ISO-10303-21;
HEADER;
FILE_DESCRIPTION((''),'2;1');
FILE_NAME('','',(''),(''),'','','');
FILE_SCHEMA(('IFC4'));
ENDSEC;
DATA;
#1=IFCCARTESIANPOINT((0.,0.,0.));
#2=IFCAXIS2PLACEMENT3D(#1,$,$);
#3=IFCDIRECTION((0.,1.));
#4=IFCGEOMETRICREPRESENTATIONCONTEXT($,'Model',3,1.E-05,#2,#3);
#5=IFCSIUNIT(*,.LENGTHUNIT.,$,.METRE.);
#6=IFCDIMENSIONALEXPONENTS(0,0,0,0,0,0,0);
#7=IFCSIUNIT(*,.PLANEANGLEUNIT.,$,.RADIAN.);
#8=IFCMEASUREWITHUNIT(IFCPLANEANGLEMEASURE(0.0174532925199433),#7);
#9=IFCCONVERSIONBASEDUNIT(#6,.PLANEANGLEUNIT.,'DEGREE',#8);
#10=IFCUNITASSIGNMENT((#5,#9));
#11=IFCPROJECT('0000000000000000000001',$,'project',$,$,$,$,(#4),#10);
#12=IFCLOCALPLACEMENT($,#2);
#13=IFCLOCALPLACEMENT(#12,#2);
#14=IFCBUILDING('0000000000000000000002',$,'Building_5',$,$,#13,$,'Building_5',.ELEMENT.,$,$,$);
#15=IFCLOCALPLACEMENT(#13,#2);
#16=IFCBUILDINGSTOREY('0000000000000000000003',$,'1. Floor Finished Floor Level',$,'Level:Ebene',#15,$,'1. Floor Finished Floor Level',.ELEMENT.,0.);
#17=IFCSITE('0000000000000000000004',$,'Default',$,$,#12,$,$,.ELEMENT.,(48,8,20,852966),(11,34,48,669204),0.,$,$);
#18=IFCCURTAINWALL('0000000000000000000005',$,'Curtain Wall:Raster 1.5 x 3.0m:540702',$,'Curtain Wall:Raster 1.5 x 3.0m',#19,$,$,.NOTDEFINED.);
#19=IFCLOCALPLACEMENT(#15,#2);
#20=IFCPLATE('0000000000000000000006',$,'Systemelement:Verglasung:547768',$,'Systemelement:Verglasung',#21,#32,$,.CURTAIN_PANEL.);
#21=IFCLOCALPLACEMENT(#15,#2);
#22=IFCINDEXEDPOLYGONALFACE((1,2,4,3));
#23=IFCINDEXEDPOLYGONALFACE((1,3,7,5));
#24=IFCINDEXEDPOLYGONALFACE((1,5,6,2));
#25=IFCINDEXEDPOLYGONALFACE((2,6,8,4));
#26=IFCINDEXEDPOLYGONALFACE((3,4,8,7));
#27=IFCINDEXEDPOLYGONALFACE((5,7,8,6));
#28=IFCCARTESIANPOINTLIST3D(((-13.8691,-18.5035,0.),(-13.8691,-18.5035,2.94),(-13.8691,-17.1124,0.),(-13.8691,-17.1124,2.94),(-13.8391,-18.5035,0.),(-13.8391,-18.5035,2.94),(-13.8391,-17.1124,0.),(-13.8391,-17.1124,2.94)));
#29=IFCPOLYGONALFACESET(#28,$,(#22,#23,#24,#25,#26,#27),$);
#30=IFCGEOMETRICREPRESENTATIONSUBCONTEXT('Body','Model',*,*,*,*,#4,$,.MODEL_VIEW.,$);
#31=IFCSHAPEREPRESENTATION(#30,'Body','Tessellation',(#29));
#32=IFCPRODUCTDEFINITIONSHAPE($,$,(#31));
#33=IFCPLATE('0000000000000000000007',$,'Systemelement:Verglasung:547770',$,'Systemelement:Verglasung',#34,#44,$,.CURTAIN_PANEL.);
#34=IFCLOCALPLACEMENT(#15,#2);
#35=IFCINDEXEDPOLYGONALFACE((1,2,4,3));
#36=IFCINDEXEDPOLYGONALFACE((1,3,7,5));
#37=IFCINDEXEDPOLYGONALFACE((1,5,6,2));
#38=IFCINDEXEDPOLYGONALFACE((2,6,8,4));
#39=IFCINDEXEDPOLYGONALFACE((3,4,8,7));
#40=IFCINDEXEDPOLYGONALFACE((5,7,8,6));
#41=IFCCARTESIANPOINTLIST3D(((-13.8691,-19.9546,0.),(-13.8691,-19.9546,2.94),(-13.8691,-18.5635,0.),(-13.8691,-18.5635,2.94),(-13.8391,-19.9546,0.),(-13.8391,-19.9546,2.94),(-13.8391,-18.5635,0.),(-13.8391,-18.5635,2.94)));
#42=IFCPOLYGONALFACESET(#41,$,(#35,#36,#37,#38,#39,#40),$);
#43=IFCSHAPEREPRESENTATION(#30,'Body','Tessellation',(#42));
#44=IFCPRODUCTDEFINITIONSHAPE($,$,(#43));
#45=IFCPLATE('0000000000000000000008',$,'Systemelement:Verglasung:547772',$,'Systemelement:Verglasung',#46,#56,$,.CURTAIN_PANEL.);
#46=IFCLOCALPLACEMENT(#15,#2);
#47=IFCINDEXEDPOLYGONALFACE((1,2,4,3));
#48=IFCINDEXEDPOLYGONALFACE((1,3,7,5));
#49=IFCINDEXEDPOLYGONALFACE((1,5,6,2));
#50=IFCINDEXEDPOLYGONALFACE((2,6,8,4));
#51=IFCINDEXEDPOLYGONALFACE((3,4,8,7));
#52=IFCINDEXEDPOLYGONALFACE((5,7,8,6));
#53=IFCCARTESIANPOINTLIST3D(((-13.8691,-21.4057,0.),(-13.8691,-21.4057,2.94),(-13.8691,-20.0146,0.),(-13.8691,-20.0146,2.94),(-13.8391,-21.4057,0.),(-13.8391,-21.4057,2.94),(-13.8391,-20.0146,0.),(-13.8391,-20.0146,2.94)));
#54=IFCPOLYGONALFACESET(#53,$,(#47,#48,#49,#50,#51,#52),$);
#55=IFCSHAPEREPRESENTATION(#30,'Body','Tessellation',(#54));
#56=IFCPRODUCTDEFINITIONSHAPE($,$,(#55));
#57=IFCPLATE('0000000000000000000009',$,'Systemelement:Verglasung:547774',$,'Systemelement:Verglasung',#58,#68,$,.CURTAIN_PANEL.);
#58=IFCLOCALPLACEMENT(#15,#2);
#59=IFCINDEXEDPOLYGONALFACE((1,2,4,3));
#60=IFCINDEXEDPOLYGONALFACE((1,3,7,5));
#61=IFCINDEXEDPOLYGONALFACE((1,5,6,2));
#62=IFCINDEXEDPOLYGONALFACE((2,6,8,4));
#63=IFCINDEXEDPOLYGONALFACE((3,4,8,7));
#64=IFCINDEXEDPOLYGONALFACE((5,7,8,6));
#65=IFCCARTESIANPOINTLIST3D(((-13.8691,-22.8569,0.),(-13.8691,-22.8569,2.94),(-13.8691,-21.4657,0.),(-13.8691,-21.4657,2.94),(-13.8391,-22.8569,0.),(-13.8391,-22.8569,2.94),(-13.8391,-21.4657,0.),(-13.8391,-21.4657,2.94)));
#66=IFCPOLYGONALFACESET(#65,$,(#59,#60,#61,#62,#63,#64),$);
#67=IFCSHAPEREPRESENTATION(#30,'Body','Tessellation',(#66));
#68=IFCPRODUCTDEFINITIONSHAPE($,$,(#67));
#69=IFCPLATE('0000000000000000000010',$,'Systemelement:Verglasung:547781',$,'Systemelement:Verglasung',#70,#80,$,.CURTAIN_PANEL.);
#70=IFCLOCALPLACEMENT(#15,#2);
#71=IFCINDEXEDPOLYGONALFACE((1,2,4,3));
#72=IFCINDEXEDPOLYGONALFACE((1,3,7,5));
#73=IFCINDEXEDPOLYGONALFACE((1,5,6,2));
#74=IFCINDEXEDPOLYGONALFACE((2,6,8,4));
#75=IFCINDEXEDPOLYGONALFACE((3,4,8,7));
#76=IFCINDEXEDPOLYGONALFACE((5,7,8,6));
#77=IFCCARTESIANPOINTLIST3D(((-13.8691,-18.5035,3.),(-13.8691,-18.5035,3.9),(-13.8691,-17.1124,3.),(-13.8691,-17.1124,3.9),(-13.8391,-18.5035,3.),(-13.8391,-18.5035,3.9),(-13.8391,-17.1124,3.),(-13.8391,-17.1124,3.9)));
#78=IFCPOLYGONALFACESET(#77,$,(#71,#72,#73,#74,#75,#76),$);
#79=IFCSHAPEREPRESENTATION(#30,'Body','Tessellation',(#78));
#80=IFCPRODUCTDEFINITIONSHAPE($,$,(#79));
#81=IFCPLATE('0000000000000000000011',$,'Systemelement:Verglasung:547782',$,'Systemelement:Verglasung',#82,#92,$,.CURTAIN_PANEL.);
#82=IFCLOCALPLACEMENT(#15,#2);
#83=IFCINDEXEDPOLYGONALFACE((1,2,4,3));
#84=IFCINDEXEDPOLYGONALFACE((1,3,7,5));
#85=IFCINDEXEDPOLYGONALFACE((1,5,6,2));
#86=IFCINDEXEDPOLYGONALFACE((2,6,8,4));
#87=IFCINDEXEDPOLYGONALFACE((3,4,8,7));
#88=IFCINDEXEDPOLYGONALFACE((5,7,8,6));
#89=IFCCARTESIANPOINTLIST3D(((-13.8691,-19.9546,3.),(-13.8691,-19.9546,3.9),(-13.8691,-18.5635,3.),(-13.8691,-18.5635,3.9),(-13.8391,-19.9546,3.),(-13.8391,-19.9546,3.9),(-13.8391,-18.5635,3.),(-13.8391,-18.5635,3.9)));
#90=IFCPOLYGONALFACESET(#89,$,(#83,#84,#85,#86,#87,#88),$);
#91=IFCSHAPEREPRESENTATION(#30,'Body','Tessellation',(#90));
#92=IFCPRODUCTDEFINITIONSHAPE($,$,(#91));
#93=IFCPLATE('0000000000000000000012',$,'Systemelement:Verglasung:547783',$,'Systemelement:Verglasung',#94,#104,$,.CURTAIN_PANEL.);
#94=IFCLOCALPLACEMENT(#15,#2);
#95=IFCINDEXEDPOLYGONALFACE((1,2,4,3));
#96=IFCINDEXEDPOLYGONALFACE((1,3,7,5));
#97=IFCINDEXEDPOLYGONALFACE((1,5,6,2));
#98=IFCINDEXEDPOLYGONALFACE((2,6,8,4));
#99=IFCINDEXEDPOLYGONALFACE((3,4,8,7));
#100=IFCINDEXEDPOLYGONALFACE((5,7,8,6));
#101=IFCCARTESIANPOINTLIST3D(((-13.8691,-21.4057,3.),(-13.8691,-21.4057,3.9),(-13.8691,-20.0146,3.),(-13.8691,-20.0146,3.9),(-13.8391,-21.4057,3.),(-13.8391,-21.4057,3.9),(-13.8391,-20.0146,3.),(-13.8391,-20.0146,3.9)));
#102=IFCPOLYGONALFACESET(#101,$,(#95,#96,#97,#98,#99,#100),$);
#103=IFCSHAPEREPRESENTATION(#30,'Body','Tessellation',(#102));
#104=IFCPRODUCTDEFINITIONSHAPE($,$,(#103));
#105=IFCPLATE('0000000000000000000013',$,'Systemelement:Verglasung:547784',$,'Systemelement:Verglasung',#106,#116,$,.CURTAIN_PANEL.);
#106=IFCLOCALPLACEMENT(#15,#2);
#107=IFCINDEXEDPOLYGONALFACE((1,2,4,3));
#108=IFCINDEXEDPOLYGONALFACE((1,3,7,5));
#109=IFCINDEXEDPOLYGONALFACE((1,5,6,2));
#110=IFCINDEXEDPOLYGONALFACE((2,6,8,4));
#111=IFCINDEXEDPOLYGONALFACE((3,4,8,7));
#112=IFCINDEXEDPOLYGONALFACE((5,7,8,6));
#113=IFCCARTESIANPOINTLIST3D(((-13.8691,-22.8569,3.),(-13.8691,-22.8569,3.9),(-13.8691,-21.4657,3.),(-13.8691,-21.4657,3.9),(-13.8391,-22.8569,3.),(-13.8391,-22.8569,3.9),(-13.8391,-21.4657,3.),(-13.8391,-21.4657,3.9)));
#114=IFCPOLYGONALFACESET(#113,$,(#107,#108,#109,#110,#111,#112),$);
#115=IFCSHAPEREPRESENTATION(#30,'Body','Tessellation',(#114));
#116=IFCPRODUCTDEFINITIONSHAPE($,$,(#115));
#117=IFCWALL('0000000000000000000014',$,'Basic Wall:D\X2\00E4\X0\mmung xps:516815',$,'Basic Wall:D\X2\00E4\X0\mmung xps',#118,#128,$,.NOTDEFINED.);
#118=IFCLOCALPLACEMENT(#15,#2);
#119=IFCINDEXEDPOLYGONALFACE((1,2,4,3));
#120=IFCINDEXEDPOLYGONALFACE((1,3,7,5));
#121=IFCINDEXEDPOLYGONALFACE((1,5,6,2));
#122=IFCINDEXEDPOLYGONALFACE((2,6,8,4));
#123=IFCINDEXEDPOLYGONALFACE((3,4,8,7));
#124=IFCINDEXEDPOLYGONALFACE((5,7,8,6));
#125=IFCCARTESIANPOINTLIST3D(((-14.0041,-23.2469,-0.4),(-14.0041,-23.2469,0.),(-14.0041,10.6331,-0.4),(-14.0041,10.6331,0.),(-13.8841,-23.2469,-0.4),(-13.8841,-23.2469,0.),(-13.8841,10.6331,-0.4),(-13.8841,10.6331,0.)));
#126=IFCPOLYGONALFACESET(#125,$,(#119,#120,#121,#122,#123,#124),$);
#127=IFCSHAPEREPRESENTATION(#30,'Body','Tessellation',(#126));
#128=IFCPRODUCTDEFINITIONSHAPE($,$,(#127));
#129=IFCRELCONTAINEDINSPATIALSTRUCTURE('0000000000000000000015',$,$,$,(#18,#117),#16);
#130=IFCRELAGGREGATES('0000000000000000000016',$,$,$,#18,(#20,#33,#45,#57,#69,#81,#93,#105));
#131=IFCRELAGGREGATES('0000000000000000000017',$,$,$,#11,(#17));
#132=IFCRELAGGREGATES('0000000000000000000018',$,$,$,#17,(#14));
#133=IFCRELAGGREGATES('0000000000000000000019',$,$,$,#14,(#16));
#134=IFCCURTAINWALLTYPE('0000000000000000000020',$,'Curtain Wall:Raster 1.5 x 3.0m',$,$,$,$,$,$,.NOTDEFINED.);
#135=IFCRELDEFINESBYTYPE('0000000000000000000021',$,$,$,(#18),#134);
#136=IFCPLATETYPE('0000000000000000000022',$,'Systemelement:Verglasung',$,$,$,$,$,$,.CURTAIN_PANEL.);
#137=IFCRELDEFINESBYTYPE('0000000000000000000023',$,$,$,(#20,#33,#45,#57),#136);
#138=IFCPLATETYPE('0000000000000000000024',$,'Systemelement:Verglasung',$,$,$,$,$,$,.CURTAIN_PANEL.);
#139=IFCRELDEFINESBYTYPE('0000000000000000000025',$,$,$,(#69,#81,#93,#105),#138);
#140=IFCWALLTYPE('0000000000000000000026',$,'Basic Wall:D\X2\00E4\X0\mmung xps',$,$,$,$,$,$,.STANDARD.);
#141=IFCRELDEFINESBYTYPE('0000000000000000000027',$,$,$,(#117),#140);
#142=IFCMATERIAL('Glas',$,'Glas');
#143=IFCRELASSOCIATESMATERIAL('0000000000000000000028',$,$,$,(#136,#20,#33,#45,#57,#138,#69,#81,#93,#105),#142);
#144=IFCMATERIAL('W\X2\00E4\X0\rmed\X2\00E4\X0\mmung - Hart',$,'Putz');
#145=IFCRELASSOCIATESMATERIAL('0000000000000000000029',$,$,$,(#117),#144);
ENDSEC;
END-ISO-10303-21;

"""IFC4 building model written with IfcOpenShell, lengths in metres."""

from ifc_helpers import new_model, entity, si_unit, converted_unit, direction, frame, origin, place, context, subcontext, project, spatial, indexed_curve, outline, extrude, source, transform, mapped, material, type_object, type_shapes, element, aggregate, save


model = new_model("IFC4")

# Units and contexts
model_context = context("Model", 3, precision=1e-05, world=origin(), true_north=direction((0.0, 1.0)))
body_context = subcontext(model_context, "Body", "Model", "MODEL_VIEW")
ifc_project = project(units=[si_unit("LENGTHUNIT", "METRE"), converted_unit("PLANEANGLEUNIT", "DEGREE", entity("IfcPlaneAngleMeasure", 0.0174532925199433), si_unit("PLANEANGLEUNIT", "RADIAN"), dimensions=[0, 0, 0, 0, 0, 0, 0])], contexts=[model_context])

# Site, building, storey
site_placement = place(None, origin())
site = spatial("IfcSite", under=ifc_project, at=site_placement, Name="Default", CompositionType="ELEMENT", RefLatitude=(48, 8, 20, 852966), RefLongitude=(11, 34, 48, 669204), RefElevation=0.0)
building_placement = place(site_placement, origin())
building = spatial("IfcBuilding", under=site, at=building_placement, Name="Building_5", LongName="Building_5", CompositionType="ELEMENT")
storey_placement = place(building_placement, origin())
storey = spatial("IfcBuildingStorey", under=building, at=storey_placement, Name="1. Floor Finished Floor Level", ObjectType="Level:Ebene", LongName="1. Floor Finished Floor Level", CompositionType="ELEMENT", Elevation=0.0)

# Curtain wall, plates
curtain_wall_type = type_object("IfcCurtainWallType", Name="Curtain Wall:Raster 1.5 x 3.0m", PredefinedType="NOTDEFINED")
curtain_wall_placement = place(storey_placement, origin())
curtain_wall = element("IfcCurtainWall", 1, at=curtain_wall_placement, inside=storey, type_object=curtain_wall_type, Name="Curtain Wall:Raster 1.5 x 3.0m:540702", ObjectType="Curtain Wall:Raster 1.5 x 3.0m", PredefinedType="NOTDEFINED")
ifc_material_1 = material(Name="Glas", Category="Glas")
plate_type_1 = type_object("IfcPlateType", Name="Systemelement:Verglasung", PredefinedType="CURTAIN_PANEL", material=ifc_material_1)
shared_shape_1 = source(origin(), body_context, "Body", "SweptSolid", [
    extrude(outline(indexed_curve([(-0.015, -0.6956), (0.015, -0.6956), (0.015, 0.6956), (-0.015, 0.6956), (-0.015, -0.6956)], self_intersect=False)), frame((0.0, 0.0, 0.0), z_axis=(0.0, 0.0, 1.0), x_axis=(0.0, 1.0, 0.0)), (0.0, 0.0, 1.0), 2.94),
])
type_shapes(plate_type_1, [shared_shape_1])
plate_1_placement = place(curtain_wall_placement, frame((-13.8541, -17.808, 0.0), z_axis=(0.0, 0.0, 1.0), x_axis=(0.0, -1.0, 0.0)))
plate_1 = element("IfcPlate", 2, at=plate_1_placement, type_object=plate_type_1, material=ifc_material_1, Name="Systemelement:Verglasung:547768", ObjectType="Systemelement:Verglasung", PredefinedType="CURTAIN_PANEL", context=body_context, shape_type="MappedRepresentation", body=[
    mapped(shared_shape_1, transform((0.0, 0.0, 0.0), scale=1.0)),
])
plate_2_placement = place(curtain_wall_placement, frame((-13.8541, -19.2591, 0.0), z_axis=(0.0, 0.0, 1.0), x_axis=(0.0, -1.0, 0.0)))
plate_2 = element("IfcPlate", 3, at=plate_2_placement, type_object=plate_type_1, material=ifc_material_1, Name="Systemelement:Verglasung:547770", ObjectType="Systemelement:Verglasung", PredefinedType="CURTAIN_PANEL", context=body_context, shape_type="MappedRepresentation", body=[
    mapped(shared_shape_1, transform((0.0, 0.0, 0.0), scale=1.0)),
])
plate_3_placement = place(curtain_wall_placement, frame((-13.8541, -20.7102, 0.0), z_axis=(0.0, 0.0, 1.0), x_axis=(0.0, -1.0, 0.0)))
plate_3 = element("IfcPlate", 4, at=plate_3_placement, type_object=plate_type_1, material=ifc_material_1, Name="Systemelement:Verglasung:547772", ObjectType="Systemelement:Verglasung", PredefinedType="CURTAIN_PANEL", context=body_context, shape_type="MappedRepresentation", body=[
    mapped(shared_shape_1, transform((0.0, 0.0, 0.0), scale=1.0)),
])
plate_4_placement = place(curtain_wall_placement, frame((-13.8541, -22.1613, 0.0), z_axis=(0.0, 0.0, 1.0), x_axis=(0.0, -1.0, 0.0)))
plate_4 = element("IfcPlate", 5, at=plate_4_placement, type_object=plate_type_1, material=ifc_material_1, Name="Systemelement:Verglasung:547774", ObjectType="Systemelement:Verglasung", PredefinedType="CURTAIN_PANEL", context=body_context, shape_type="MappedRepresentation", body=[
    mapped(shared_shape_1, transform((0.0, 0.0, 0.0), scale=1.0)),
])
plate_type_2 = type_object("IfcPlateType", Name="Systemelement:Verglasung", PredefinedType="CURTAIN_PANEL", material=ifc_material_1)
shared_shape_2 = source(origin(), body_context, "Body", "SweptSolid", [
    extrude(outline(indexed_curve([(-0.015, -0.6956), (0.015, -0.6956), (0.015, 0.6956), (-0.015, 0.6956), (-0.015, -0.6956)], self_intersect=False)), frame((0.0, 0.0, 0.0), z_axis=(0.0, 0.0, 1.0), x_axis=(0.0, 1.0, 0.0)), (0.0, 0.0, 1.0), 0.9),
])
type_shapes(plate_type_2, [shared_shape_2])
plate_5_placement = place(curtain_wall_placement, frame((-13.8541, -17.808, 3.0), z_axis=(0.0, 0.0, 1.0), x_axis=(0.0, -1.0, 0.0)))
plate_5 = element("IfcPlate", 6, at=plate_5_placement, type_object=plate_type_2, material=ifc_material_1, Name="Systemelement:Verglasung:547781", ObjectType="Systemelement:Verglasung", PredefinedType="CURTAIN_PANEL", context=body_context, shape_type="MappedRepresentation", body=[
    mapped(shared_shape_2, transform((0.0, 0.0, 0.0), scale=1.0)),
])
plate_6_placement = place(curtain_wall_placement, frame((-13.8541, -19.2591, 3.0), z_axis=(0.0, 0.0, 1.0), x_axis=(0.0, -1.0, 0.0)))
plate_6 = element("IfcPlate", 7, at=plate_6_placement, type_object=plate_type_2, material=ifc_material_1, Name="Systemelement:Verglasung:547782", ObjectType="Systemelement:Verglasung", PredefinedType="CURTAIN_PANEL", context=body_context, shape_type="MappedRepresentation", body=[
    mapped(shared_shape_2, transform((0.0, 0.0, 0.0), scale=1.0)),
])
plate_7_placement = place(curtain_wall_placement, frame((-13.8541, -20.7102, 3.0), z_axis=(0.0, 0.0, 1.0), x_axis=(0.0, -1.0, 0.0)))
plate_7 = element("IfcPlate", 8, at=plate_7_placement, type_object=plate_type_2, material=ifc_material_1, Name="Systemelement:Verglasung:547783", ObjectType="Systemelement:Verglasung", PredefinedType="CURTAIN_PANEL", context=body_context, shape_type="MappedRepresentation", body=[
    mapped(shared_shape_2, transform((0.0, 0.0, 0.0), scale=1.0)),
])
plate_8_placement = place(curtain_wall_placement, frame((-13.8541, -22.1613, 3.0), z_axis=(0.0, 0.0, 1.0), x_axis=(0.0, -1.0, 0.0)))
plate_8 = element("IfcPlate", 9, at=plate_8_placement, type_object=plate_type_2, material=ifc_material_1, Name="Systemelement:Verglasung:547784", ObjectType="Systemelement:Verglasung", PredefinedType="CURTAIN_PANEL", context=body_context, shape_type="MappedRepresentation", body=[
    mapped(shared_shape_2, transform((0.0, 0.0, 0.0), scale=1.0)),
])
aggregate(curtain_wall, [plate_1, plate_2, plate_3, plate_4, plate_5, plate_6, plate_7, plate_8])

# Wall
ifc_material_2 = material(Name="Wärmedämmung - Hart", Category="Putz")
wall_type = type_object("IfcWallType", Name="Basic Wall:Dämmung xps", PredefinedType="STANDARD")
wall_placement = place(storey_placement, frame((-13.9441, -23.2469, -0.4), z_axis=(0.0, 0.0, 1.0), x_axis=(0.0, 1.0, 0.0)))
element("IfcWall", 10, at=wall_placement, inside=storey, type_object=wall_type, material=ifc_material_2, Name="Basic Wall:Dämmung xps:516815", ObjectType="Basic Wall:Dämmung xps", PredefinedType="NOTDEFINED", context=body_context, shape_type="SweptSolid", body=[
    extrude(outline(indexed_curve([(33.88, 0.06), (0.0, 0.06), (0.0, -0.06), (33.88, -0.06), (33.88, 0.06)], self_intersect=False)), origin(), (0.0, 0.0, 1.0), 0.4),
])

save(model, "model.ifc")
